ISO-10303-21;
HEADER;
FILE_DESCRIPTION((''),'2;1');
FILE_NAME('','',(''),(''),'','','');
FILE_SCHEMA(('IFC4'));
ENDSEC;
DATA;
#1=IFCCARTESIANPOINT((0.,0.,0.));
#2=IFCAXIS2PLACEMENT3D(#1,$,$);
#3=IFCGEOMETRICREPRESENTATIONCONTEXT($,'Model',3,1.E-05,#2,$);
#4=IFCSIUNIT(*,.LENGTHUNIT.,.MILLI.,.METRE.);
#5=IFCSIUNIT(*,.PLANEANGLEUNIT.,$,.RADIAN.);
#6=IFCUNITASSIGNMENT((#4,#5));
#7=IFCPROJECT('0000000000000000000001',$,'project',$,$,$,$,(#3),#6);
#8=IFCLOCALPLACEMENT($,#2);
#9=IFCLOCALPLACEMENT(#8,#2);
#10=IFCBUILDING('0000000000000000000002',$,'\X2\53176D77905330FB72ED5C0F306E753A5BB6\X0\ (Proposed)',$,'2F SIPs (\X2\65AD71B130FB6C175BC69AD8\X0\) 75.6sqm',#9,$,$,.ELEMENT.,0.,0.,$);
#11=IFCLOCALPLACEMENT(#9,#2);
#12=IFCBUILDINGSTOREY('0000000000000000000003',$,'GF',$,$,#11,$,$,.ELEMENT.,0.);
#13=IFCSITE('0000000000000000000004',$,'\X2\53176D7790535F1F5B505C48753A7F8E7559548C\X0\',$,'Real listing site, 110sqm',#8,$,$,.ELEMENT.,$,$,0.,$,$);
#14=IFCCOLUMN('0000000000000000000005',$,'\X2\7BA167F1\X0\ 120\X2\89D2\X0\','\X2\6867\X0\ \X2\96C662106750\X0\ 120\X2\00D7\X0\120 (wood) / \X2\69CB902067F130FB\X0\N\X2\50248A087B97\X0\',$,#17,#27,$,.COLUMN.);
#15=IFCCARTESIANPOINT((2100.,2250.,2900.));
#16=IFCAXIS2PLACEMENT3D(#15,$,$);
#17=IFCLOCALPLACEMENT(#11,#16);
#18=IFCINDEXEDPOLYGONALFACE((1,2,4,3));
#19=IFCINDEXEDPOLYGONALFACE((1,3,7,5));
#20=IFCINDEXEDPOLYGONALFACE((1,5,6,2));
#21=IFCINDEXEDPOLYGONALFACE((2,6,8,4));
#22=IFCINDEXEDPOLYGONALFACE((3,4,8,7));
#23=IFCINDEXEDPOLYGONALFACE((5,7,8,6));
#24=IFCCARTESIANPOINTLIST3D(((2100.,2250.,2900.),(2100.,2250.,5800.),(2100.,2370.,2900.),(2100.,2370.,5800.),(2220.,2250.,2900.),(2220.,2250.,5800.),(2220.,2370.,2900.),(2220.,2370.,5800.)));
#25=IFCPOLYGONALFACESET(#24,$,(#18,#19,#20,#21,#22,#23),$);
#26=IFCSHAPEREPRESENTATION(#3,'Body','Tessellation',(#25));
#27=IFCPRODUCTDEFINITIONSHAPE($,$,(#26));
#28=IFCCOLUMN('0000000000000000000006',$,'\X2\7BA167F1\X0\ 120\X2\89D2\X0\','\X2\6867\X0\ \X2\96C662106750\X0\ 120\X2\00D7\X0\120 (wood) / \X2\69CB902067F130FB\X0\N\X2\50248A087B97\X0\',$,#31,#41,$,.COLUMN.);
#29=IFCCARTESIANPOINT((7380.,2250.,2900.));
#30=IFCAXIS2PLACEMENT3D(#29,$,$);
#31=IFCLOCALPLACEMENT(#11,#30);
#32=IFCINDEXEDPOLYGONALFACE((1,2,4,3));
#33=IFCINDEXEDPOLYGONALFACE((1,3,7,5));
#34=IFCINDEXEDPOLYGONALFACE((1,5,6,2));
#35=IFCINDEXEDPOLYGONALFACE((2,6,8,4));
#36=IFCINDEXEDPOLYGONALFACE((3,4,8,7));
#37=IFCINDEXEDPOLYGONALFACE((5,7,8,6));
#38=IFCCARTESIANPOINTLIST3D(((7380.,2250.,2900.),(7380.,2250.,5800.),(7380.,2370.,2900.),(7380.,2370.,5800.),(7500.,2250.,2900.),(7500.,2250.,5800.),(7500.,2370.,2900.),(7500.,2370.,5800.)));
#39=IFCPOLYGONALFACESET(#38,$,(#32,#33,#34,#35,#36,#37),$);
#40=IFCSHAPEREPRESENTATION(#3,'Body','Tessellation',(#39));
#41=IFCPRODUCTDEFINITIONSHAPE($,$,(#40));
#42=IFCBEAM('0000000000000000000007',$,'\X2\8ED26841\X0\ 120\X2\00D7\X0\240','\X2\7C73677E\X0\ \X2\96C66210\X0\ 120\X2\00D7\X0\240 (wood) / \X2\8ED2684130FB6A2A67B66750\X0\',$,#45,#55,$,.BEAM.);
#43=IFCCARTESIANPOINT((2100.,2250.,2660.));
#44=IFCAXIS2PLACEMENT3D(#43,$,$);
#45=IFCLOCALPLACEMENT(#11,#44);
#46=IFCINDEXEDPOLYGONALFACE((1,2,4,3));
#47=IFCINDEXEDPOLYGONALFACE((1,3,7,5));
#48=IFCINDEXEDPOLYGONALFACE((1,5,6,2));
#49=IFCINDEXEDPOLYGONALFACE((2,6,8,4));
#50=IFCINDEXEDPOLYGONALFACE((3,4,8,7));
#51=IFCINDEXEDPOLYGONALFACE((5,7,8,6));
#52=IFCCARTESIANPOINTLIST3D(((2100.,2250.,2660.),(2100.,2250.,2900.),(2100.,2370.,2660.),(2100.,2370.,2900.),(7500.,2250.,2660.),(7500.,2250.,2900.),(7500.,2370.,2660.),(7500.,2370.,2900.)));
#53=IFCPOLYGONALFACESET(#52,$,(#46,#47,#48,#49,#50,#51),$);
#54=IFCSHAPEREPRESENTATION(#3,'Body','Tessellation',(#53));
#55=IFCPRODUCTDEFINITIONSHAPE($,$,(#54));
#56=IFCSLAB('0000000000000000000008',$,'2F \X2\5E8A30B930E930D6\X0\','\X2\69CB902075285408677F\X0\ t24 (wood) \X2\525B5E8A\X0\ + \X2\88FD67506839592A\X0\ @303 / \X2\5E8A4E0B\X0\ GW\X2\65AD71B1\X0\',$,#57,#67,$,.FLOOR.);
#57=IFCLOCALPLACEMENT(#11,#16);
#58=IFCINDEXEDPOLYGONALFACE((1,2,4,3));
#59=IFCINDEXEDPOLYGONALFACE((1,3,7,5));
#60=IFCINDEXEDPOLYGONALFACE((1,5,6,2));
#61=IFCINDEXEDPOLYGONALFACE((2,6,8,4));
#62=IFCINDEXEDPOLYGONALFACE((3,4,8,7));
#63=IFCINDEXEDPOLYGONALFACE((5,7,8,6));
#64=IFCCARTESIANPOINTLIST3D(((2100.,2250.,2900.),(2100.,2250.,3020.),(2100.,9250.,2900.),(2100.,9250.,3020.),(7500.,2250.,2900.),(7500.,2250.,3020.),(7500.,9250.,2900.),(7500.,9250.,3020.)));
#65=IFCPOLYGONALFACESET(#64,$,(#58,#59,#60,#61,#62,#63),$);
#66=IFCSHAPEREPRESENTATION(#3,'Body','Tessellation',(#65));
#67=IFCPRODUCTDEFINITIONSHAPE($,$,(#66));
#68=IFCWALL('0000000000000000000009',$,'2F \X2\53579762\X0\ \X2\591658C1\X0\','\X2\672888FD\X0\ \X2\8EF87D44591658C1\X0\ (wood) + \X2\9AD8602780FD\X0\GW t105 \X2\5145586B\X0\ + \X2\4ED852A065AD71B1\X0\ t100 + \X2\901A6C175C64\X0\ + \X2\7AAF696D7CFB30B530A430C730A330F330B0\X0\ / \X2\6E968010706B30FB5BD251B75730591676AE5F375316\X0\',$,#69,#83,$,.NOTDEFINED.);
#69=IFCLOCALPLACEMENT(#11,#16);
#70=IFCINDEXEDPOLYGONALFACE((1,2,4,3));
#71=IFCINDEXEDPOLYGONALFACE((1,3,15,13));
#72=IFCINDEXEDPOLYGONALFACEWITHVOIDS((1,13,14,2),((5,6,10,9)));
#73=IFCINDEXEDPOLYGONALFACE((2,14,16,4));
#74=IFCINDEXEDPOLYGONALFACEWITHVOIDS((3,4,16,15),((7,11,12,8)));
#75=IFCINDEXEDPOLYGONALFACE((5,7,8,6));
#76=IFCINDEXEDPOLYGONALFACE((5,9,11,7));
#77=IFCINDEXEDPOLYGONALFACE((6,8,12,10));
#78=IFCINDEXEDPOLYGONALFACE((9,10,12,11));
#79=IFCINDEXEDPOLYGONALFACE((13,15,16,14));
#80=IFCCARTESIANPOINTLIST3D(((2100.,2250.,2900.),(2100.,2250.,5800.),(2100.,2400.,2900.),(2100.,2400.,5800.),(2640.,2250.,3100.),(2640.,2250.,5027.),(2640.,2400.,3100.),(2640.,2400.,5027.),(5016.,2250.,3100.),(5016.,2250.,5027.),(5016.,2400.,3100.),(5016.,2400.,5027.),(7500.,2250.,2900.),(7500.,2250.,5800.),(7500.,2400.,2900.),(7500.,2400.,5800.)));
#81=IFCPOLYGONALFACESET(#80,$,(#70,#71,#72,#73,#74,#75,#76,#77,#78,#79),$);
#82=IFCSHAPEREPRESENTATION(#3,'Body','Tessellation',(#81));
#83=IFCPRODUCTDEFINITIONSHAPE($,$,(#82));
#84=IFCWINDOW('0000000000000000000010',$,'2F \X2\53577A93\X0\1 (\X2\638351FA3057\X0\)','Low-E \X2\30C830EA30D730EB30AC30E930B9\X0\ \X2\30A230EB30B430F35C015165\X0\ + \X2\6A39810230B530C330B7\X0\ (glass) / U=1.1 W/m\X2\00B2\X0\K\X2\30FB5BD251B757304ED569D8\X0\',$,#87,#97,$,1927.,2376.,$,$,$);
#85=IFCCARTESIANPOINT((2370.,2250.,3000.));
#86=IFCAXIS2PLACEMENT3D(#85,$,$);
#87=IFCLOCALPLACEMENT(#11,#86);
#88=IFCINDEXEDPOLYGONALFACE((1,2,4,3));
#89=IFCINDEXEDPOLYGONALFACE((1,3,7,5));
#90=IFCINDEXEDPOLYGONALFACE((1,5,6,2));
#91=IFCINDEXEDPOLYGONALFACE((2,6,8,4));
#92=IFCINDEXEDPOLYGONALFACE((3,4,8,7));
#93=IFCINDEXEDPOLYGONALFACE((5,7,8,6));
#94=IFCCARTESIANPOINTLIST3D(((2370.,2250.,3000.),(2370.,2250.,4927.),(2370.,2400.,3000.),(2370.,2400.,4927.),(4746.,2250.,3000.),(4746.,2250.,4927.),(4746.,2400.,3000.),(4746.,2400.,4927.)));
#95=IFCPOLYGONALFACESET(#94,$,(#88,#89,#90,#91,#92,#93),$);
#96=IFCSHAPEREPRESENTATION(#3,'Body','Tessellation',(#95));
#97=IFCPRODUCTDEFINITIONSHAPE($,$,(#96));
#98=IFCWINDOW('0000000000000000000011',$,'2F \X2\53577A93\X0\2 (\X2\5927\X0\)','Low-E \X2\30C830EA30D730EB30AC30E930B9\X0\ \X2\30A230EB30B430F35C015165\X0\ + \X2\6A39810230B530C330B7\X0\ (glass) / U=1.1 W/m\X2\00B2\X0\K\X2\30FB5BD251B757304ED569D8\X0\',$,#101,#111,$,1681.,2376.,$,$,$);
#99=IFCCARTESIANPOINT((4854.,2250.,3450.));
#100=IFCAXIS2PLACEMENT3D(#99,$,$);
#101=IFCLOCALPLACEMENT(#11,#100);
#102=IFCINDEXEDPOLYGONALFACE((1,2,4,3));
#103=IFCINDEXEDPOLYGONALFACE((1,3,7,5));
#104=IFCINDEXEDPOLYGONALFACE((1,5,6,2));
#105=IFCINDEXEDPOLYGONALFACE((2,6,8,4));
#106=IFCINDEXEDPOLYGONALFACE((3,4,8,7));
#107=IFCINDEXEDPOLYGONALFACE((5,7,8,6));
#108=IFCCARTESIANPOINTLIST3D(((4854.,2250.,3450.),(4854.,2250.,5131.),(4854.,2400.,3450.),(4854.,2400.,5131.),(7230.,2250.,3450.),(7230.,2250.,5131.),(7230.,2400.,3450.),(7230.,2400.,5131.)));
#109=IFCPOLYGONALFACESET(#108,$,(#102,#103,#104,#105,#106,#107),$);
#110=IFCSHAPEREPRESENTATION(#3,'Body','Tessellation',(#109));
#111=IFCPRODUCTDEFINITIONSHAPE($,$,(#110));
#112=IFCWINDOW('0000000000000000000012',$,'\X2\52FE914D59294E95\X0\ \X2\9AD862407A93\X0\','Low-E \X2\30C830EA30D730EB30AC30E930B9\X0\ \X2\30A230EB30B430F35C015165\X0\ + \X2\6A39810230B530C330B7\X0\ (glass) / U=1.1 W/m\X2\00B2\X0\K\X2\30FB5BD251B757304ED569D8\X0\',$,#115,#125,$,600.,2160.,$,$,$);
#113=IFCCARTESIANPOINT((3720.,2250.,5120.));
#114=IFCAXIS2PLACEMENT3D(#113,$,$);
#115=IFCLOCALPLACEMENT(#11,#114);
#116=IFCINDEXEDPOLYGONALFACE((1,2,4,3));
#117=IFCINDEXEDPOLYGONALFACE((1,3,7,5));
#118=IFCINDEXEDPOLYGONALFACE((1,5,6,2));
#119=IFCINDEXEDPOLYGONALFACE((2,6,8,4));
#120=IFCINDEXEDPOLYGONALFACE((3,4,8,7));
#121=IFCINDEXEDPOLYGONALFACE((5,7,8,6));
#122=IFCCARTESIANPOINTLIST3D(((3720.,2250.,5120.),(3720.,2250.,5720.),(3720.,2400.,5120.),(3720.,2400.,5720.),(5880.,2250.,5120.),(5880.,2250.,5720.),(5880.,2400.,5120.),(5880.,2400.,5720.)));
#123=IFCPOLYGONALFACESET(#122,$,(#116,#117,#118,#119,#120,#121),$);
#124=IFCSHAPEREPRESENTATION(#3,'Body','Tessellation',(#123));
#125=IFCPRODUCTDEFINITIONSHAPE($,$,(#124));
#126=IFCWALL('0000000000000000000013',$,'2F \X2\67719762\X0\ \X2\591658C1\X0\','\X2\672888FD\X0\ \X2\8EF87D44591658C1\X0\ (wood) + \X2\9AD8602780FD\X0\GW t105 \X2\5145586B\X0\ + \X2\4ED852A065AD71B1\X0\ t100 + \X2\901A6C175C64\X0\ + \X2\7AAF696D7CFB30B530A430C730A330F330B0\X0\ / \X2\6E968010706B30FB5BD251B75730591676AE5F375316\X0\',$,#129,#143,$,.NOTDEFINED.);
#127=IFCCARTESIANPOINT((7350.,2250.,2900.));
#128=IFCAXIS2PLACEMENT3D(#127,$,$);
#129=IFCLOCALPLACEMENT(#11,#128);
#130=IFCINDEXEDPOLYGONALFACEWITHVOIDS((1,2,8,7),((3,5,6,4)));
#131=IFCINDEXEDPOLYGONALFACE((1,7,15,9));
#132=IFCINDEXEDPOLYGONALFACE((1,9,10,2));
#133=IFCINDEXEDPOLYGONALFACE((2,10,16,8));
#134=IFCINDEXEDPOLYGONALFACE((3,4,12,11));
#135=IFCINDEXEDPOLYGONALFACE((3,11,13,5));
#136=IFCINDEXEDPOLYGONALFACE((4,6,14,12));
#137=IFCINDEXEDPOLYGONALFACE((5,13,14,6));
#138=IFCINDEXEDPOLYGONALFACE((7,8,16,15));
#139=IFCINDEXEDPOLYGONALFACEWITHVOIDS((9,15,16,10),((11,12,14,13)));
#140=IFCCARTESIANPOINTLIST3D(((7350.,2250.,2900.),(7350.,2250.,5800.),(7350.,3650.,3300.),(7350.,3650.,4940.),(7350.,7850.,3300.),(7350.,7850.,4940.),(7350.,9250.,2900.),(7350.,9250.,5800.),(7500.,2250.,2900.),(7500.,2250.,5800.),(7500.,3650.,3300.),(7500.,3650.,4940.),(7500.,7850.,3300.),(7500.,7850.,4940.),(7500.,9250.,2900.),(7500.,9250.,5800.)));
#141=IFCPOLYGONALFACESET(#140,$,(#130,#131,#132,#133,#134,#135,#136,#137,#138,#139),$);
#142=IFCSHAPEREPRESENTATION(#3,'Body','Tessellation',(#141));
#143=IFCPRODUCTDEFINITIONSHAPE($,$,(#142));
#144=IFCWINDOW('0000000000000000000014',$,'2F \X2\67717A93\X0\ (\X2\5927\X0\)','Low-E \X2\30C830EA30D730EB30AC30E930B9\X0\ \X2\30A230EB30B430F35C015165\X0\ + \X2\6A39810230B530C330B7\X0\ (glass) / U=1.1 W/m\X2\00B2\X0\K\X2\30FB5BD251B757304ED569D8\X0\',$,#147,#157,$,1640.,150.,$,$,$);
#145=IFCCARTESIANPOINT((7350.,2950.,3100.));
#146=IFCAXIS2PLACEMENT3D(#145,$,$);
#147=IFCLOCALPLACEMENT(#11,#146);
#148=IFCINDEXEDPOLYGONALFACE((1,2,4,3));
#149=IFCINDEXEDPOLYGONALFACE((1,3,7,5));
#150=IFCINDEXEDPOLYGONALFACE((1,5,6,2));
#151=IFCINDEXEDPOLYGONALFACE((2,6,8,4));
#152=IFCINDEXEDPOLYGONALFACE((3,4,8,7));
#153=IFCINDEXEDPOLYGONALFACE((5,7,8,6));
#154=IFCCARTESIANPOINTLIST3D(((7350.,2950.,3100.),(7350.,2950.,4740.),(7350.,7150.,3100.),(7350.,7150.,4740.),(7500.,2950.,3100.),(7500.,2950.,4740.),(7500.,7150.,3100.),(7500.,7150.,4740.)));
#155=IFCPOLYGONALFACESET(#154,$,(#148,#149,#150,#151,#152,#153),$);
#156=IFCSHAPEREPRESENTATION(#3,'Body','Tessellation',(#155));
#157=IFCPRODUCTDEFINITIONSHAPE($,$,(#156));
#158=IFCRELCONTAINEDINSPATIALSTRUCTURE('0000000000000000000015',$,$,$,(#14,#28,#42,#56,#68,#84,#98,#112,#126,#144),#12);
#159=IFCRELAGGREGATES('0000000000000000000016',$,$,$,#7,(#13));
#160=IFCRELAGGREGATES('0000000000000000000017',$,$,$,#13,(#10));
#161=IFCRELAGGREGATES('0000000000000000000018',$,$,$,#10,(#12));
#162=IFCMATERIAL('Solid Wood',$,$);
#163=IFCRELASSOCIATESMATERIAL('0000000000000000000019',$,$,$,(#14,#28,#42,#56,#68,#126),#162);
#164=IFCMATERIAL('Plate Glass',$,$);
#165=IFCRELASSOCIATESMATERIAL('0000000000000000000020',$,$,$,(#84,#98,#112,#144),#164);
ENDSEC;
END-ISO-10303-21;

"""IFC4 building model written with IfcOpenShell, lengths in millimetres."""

from ifc_helpers import new_model, si_unit, frame, frame_2d, origin, place, context, project, spatial, rectangle, extrude, material, element, fill, save


model = new_model("IFC4")

# Units and contexts
model_context = context("Model", 3, precision=1e-05, world=origin())
ifc_project = project(units=[si_unit("LENGTHUNIT", "METRE", prefix="MILLI"), si_unit("PLANEANGLEUNIT", "RADIAN")], contexts=[model_context])

# Site, building, storey
site_placement = place(None, origin())
site = spatial("IfcSite", under=ifc_project, at=site_placement, Name="北海道弟子屈町美留和", ObjectType="Real listing site, 110sqm", CompositionType="ELEMENT", RefElevation=0.0)
building_placement = place(site_placement, origin())
building = spatial("IfcBuilding", under=site, at=building_placement, Name="北海道・狭小の町家 (Proposed)", ObjectType="2F SIPs (断熱・気密高) 75.6sqm", CompositionType="ELEMENT", ElevationOfRefHeight=0.0, ElevationOfTerrain=0.0)
storey_placement = place(building_placement, origin())
storey = spatial("IfcBuildingStorey", under=building, at=storey_placement, Name="GF", CompositionType="ELEMENT", Elevation=0.0)

# Columns
ifc_material_1 = material(Name="Solid Wood")
column_1_placement = place(storey_placement, frame((2100.0, 2250.0, 2900.0)))
element("IfcColumn", 1, at=column_1_placement, inside=storey, material=ifc_material_1, Name="管柱 120角", Description="桧 集成材 120×120 (wood) / 構造柱・N値計算", PredefinedType="COLUMN", context=model_context, shape_type="SweptSolid", body=[
    extrude(rectangle(XDim=120.0, YDim=120.0, at=frame_2d((60.0, 60.0))), frame((2100.0, 2250.0, 2900.0)), (0.0, 0.0, 1.0), 2900.0),
])
column_2_placement = place(storey_placement, frame((7380.0, 2250.0, 2900.0)))
element("IfcColumn", 2, at=column_2_placement, inside=storey, material=ifc_material_1, Name="管柱 120角", Description="桧 集成材 120×120 (wood) / 構造柱・N値計算", PredefinedType="COLUMN", context=model_context, shape_type="SweptSolid", body=[
    extrude(rectangle(XDim=120.0, YDim=120.0, at=frame_2d((60.0, 60.0))), frame((7380.0, 2250.0, 2900.0)), (0.0, 0.0, 1.0), 2900.0),
])

# Beam
beam_1_placement = place(storey_placement, frame((2100.0, 2250.0, 2660.0)))
element("IfcBeam", 3, at=beam_1_placement, inside=storey, material=ifc_material_1, Name="軒桁 120×240", Description="米松 集成 120×240 (wood) / 軒桁・横架材", PredefinedType="BEAM", context=model_context, shape_type="SweptSolid", body=[
    extrude(rectangle(XDim=5400.0, YDim=120.0, at=frame_2d((2700.0, 60.0))), frame((2100.0, 2250.0, 2660.0)), (0.0, 0.0, 1.0), 240.0),
])

# Slab
slab_placement = place(storey_placement, frame((2100.0, 2250.0, 2900.0)))
element("IfcSlab", 4, at=slab_placement, inside=storey, material=ifc_material_1, Name="2F 床スラブ", Description="構造用合板 t24 (wood) 剛床 + 製材根太 @303 / 床下 GW断熱", PredefinedType="FLOOR", context=model_context, shape_type="SweptSolid", body=[
    extrude(rectangle(XDim=5400.0, YDim=7000.0, at=frame_2d((2700.0, 3500.0))), frame((2100.0, 2250.0, 2900.0)), (0.0, 0.0, 1.0), 120.0),
])

# Wall, openings, windows
wall_1_placement = place(storey_placement, frame((2100.0, 2250.0, 2900.0)))
wall_1 = element("IfcWall", 5, at=wall_1_placement, inside=storey, material=ifc_material_1, Name="2F 南面 外壁", Description="木製 軸組外壁 (wood) + 高性能GW t105 充填 + 付加断熱 t100 + 通気層 + 窯業系サイディング / 準耐火・寒冷地外皮強化", PredefinedType="NOTDEFINED", context=model_context, shape_type="SweptSolid", body=[
    extrude(rectangle(XDim=5400.0, YDim=150.0, at=frame_2d((2700.0, 75.0))), frame((2100.0, 2250.0, 2900.0)), (0.0, 0.0, 1.0), 2900.0),
])
opening_1_placement = place(storey_placement, frame((2370.0, 2250.0, 3000.0)))
opening_1 = element("IfcOpeningElement", 6, at=opening_1_placement, cuts=wall_1, PredefinedType="NOTDEFINED", context=model_context, shape_type="SweptSolid", body=[
    extrude(rectangle(XDim=2376.0, YDim=150.0, at=frame_2d((1188.0, 75.0))), frame((2370.0, 2250.0, 3000.0)), (0.0, 0.0, 1.0), 1927.0),
])
opening_2_placement = place(storey_placement, frame((4854.0, 2250.0, 3450.0)))
opening_2 = element("IfcOpeningElement", 7, at=opening_2_placement, cuts=wall_1, PredefinedType="NOTDEFINED", context=model_context, shape_type="SweptSolid", body=[
    extrude(rectangle(XDim=2376.0, YDim=150.0, at=frame_2d((1188.0, 75.0))), frame((4854.0, 2250.0, 3450.0)), (0.0, 0.0, 1.0), 1681.0),
])
opening_3_placement = place(storey_placement, frame((3720.0, 2250.0, 5120.0)))
opening_3 = element("IfcOpeningElement", 8, at=opening_3_placement, cuts=wall_1, PredefinedType="NOTDEFINED", context=model_context, shape_type="SweptSolid", body=[
    extrude(rectangle(XDim=2160.0, YDim=150.0, at=frame_2d((1080.0, 75.0))), frame((3720.0, 2250.0, 5120.0)), (0.0, 0.0, 1.0), 600.0),
])
ifc_material_2 = material(Name="Plate Glass")
window_1_placement = place(storey_placement, frame((2370.0, 2250.0, 3000.0)))
window_1 = element("IfcWindow", 9, at=window_1_placement, inside=storey, material=ifc_material_2, Name="2F 南窓1 (掃出し)", Description="Low-E トリプルガラス アルゴン封入 + 樹脂サッシ (glass) / U=1.1 W/m²K・寒冷地仕様", OverallHeight=1927.0, OverallWidth=2376.0, context=model_context, shape_type="SweptSolid", body=[
    extrude(rectangle(XDim=2376.0, YDim=150.0, at=frame_2d((1188.0, 75.0))), frame((2370.0, 2250.0, 3000.0)), (0.0, 0.0, 1.0), 1927.0),
])
fill(opening_1, window_1)
window_2_placement = place(storey_placement, frame((4854.0, 2250.0, 3450.0)))
window_2 = element("IfcWindow", 10, at=window_2_placement, inside=storey, material=ifc_material_2, Name="2F 南窓2 (大)", Description="Low-E トリプルガラス アルゴン封入 + 樹脂サッシ (glass) / U=1.1 W/m²K・寒冷地仕様", OverallHeight=1681.0, OverallWidth=2376.0, context=model_context, shape_type="SweptSolid", body=[
    extrude(rectangle(XDim=2376.0, YDim=150.0, at=frame_2d((1188.0, 75.0))), frame((4854.0, 2250.0, 3450.0)), (0.0, 0.0, 1.0), 1681.0),
])
fill(opening_2, window_2)
window_3_placement = place(storey_placement, frame((3720.0, 2250.0, 5120.0)))
window_3 = element("IfcWindow", 11, at=window_3_placement, inside=storey, material=ifc_material_2, Name="勾配天井 高所窓", Description="Low-E トリプルガラス アルゴン封入 + 樹脂サッシ (glass) / U=1.1 W/m²K・寒冷地仕様", OverallHeight=600.0, OverallWidth=2160.0, context=model_context, shape_type="SweptSolid", body=[
    extrude(rectangle(XDim=2160.0, YDim=150.0, at=frame_2d((1080.0, 75.0))), frame((3720.0, 2250.0, 5120.0)), (0.0, 0.0, 1.0), 600.0),
])
fill(opening_3, window_3)

# Wall, opening, window
wall_2_placement = place(storey_placement, frame((7350.0, 2250.0, 2900.0)))
wall_2 = element("IfcWall", 12, at=wall_2_placement, inside=storey, material=ifc_material_1, Name="2F 東面 外壁", Description="木製 軸組外壁 (wood) + 高性能GW t105 充填 + 付加断熱 t100 + 通気層 + 窯業系サイディング / 準耐火・寒冷地外皮強化", PredefinedType="NOTDEFINED", context=model_context, shape_type="SweptSolid", body=[
    extrude(rectangle(XDim=150.0, YDim=7000.0, at=frame_2d((75.0, 3500.0))), frame((7350.0, 2250.0, 2900.0)), (0.0, 0.0, 1.0), 2900.0),
])
opening_4_placement = place(storey_placement, frame((7350.0, 2950.0, 3100.0)))
opening_4 = element("IfcOpeningElement", 13, at=opening_4_placement, cuts=wall_2, PredefinedType="NOTDEFINED", context=model_context, shape_type="SweptSolid", body=[
    extrude(rectangle(XDim=150.0, YDim=4200.0, at=frame_2d((75.0, 2100.0))), frame((7350.0, 2950.0, 3100.0)), (0.0, 0.0, 1.0), 1640.0),
])
window_4_placement = place(storey_placement, frame((7350.0, 2950.0, 3100.0)))
window_4 = element("IfcWindow", 14, at=window_4_placement, inside=storey, material=ifc_material_2, Name="2F 東窓 (大)", Description="Low-E トリプルガラス アルゴン封入 + 樹脂サッシ (glass) / U=1.1 W/m²K・寒冷地仕様", OverallHeight=1640.0, OverallWidth=150.0, context=model_context, shape_type="SweptSolid", body=[
    extrude(rectangle(XDim=150.0, YDim=4200.0, at=frame_2d((75.0, 2100.0))), frame((7350.0, 2950.0, 3100.0)), (0.0, 0.0, 1.0), 1640.0),
])
fill(opening_4, window_4)

save(model, "model.ifc")
